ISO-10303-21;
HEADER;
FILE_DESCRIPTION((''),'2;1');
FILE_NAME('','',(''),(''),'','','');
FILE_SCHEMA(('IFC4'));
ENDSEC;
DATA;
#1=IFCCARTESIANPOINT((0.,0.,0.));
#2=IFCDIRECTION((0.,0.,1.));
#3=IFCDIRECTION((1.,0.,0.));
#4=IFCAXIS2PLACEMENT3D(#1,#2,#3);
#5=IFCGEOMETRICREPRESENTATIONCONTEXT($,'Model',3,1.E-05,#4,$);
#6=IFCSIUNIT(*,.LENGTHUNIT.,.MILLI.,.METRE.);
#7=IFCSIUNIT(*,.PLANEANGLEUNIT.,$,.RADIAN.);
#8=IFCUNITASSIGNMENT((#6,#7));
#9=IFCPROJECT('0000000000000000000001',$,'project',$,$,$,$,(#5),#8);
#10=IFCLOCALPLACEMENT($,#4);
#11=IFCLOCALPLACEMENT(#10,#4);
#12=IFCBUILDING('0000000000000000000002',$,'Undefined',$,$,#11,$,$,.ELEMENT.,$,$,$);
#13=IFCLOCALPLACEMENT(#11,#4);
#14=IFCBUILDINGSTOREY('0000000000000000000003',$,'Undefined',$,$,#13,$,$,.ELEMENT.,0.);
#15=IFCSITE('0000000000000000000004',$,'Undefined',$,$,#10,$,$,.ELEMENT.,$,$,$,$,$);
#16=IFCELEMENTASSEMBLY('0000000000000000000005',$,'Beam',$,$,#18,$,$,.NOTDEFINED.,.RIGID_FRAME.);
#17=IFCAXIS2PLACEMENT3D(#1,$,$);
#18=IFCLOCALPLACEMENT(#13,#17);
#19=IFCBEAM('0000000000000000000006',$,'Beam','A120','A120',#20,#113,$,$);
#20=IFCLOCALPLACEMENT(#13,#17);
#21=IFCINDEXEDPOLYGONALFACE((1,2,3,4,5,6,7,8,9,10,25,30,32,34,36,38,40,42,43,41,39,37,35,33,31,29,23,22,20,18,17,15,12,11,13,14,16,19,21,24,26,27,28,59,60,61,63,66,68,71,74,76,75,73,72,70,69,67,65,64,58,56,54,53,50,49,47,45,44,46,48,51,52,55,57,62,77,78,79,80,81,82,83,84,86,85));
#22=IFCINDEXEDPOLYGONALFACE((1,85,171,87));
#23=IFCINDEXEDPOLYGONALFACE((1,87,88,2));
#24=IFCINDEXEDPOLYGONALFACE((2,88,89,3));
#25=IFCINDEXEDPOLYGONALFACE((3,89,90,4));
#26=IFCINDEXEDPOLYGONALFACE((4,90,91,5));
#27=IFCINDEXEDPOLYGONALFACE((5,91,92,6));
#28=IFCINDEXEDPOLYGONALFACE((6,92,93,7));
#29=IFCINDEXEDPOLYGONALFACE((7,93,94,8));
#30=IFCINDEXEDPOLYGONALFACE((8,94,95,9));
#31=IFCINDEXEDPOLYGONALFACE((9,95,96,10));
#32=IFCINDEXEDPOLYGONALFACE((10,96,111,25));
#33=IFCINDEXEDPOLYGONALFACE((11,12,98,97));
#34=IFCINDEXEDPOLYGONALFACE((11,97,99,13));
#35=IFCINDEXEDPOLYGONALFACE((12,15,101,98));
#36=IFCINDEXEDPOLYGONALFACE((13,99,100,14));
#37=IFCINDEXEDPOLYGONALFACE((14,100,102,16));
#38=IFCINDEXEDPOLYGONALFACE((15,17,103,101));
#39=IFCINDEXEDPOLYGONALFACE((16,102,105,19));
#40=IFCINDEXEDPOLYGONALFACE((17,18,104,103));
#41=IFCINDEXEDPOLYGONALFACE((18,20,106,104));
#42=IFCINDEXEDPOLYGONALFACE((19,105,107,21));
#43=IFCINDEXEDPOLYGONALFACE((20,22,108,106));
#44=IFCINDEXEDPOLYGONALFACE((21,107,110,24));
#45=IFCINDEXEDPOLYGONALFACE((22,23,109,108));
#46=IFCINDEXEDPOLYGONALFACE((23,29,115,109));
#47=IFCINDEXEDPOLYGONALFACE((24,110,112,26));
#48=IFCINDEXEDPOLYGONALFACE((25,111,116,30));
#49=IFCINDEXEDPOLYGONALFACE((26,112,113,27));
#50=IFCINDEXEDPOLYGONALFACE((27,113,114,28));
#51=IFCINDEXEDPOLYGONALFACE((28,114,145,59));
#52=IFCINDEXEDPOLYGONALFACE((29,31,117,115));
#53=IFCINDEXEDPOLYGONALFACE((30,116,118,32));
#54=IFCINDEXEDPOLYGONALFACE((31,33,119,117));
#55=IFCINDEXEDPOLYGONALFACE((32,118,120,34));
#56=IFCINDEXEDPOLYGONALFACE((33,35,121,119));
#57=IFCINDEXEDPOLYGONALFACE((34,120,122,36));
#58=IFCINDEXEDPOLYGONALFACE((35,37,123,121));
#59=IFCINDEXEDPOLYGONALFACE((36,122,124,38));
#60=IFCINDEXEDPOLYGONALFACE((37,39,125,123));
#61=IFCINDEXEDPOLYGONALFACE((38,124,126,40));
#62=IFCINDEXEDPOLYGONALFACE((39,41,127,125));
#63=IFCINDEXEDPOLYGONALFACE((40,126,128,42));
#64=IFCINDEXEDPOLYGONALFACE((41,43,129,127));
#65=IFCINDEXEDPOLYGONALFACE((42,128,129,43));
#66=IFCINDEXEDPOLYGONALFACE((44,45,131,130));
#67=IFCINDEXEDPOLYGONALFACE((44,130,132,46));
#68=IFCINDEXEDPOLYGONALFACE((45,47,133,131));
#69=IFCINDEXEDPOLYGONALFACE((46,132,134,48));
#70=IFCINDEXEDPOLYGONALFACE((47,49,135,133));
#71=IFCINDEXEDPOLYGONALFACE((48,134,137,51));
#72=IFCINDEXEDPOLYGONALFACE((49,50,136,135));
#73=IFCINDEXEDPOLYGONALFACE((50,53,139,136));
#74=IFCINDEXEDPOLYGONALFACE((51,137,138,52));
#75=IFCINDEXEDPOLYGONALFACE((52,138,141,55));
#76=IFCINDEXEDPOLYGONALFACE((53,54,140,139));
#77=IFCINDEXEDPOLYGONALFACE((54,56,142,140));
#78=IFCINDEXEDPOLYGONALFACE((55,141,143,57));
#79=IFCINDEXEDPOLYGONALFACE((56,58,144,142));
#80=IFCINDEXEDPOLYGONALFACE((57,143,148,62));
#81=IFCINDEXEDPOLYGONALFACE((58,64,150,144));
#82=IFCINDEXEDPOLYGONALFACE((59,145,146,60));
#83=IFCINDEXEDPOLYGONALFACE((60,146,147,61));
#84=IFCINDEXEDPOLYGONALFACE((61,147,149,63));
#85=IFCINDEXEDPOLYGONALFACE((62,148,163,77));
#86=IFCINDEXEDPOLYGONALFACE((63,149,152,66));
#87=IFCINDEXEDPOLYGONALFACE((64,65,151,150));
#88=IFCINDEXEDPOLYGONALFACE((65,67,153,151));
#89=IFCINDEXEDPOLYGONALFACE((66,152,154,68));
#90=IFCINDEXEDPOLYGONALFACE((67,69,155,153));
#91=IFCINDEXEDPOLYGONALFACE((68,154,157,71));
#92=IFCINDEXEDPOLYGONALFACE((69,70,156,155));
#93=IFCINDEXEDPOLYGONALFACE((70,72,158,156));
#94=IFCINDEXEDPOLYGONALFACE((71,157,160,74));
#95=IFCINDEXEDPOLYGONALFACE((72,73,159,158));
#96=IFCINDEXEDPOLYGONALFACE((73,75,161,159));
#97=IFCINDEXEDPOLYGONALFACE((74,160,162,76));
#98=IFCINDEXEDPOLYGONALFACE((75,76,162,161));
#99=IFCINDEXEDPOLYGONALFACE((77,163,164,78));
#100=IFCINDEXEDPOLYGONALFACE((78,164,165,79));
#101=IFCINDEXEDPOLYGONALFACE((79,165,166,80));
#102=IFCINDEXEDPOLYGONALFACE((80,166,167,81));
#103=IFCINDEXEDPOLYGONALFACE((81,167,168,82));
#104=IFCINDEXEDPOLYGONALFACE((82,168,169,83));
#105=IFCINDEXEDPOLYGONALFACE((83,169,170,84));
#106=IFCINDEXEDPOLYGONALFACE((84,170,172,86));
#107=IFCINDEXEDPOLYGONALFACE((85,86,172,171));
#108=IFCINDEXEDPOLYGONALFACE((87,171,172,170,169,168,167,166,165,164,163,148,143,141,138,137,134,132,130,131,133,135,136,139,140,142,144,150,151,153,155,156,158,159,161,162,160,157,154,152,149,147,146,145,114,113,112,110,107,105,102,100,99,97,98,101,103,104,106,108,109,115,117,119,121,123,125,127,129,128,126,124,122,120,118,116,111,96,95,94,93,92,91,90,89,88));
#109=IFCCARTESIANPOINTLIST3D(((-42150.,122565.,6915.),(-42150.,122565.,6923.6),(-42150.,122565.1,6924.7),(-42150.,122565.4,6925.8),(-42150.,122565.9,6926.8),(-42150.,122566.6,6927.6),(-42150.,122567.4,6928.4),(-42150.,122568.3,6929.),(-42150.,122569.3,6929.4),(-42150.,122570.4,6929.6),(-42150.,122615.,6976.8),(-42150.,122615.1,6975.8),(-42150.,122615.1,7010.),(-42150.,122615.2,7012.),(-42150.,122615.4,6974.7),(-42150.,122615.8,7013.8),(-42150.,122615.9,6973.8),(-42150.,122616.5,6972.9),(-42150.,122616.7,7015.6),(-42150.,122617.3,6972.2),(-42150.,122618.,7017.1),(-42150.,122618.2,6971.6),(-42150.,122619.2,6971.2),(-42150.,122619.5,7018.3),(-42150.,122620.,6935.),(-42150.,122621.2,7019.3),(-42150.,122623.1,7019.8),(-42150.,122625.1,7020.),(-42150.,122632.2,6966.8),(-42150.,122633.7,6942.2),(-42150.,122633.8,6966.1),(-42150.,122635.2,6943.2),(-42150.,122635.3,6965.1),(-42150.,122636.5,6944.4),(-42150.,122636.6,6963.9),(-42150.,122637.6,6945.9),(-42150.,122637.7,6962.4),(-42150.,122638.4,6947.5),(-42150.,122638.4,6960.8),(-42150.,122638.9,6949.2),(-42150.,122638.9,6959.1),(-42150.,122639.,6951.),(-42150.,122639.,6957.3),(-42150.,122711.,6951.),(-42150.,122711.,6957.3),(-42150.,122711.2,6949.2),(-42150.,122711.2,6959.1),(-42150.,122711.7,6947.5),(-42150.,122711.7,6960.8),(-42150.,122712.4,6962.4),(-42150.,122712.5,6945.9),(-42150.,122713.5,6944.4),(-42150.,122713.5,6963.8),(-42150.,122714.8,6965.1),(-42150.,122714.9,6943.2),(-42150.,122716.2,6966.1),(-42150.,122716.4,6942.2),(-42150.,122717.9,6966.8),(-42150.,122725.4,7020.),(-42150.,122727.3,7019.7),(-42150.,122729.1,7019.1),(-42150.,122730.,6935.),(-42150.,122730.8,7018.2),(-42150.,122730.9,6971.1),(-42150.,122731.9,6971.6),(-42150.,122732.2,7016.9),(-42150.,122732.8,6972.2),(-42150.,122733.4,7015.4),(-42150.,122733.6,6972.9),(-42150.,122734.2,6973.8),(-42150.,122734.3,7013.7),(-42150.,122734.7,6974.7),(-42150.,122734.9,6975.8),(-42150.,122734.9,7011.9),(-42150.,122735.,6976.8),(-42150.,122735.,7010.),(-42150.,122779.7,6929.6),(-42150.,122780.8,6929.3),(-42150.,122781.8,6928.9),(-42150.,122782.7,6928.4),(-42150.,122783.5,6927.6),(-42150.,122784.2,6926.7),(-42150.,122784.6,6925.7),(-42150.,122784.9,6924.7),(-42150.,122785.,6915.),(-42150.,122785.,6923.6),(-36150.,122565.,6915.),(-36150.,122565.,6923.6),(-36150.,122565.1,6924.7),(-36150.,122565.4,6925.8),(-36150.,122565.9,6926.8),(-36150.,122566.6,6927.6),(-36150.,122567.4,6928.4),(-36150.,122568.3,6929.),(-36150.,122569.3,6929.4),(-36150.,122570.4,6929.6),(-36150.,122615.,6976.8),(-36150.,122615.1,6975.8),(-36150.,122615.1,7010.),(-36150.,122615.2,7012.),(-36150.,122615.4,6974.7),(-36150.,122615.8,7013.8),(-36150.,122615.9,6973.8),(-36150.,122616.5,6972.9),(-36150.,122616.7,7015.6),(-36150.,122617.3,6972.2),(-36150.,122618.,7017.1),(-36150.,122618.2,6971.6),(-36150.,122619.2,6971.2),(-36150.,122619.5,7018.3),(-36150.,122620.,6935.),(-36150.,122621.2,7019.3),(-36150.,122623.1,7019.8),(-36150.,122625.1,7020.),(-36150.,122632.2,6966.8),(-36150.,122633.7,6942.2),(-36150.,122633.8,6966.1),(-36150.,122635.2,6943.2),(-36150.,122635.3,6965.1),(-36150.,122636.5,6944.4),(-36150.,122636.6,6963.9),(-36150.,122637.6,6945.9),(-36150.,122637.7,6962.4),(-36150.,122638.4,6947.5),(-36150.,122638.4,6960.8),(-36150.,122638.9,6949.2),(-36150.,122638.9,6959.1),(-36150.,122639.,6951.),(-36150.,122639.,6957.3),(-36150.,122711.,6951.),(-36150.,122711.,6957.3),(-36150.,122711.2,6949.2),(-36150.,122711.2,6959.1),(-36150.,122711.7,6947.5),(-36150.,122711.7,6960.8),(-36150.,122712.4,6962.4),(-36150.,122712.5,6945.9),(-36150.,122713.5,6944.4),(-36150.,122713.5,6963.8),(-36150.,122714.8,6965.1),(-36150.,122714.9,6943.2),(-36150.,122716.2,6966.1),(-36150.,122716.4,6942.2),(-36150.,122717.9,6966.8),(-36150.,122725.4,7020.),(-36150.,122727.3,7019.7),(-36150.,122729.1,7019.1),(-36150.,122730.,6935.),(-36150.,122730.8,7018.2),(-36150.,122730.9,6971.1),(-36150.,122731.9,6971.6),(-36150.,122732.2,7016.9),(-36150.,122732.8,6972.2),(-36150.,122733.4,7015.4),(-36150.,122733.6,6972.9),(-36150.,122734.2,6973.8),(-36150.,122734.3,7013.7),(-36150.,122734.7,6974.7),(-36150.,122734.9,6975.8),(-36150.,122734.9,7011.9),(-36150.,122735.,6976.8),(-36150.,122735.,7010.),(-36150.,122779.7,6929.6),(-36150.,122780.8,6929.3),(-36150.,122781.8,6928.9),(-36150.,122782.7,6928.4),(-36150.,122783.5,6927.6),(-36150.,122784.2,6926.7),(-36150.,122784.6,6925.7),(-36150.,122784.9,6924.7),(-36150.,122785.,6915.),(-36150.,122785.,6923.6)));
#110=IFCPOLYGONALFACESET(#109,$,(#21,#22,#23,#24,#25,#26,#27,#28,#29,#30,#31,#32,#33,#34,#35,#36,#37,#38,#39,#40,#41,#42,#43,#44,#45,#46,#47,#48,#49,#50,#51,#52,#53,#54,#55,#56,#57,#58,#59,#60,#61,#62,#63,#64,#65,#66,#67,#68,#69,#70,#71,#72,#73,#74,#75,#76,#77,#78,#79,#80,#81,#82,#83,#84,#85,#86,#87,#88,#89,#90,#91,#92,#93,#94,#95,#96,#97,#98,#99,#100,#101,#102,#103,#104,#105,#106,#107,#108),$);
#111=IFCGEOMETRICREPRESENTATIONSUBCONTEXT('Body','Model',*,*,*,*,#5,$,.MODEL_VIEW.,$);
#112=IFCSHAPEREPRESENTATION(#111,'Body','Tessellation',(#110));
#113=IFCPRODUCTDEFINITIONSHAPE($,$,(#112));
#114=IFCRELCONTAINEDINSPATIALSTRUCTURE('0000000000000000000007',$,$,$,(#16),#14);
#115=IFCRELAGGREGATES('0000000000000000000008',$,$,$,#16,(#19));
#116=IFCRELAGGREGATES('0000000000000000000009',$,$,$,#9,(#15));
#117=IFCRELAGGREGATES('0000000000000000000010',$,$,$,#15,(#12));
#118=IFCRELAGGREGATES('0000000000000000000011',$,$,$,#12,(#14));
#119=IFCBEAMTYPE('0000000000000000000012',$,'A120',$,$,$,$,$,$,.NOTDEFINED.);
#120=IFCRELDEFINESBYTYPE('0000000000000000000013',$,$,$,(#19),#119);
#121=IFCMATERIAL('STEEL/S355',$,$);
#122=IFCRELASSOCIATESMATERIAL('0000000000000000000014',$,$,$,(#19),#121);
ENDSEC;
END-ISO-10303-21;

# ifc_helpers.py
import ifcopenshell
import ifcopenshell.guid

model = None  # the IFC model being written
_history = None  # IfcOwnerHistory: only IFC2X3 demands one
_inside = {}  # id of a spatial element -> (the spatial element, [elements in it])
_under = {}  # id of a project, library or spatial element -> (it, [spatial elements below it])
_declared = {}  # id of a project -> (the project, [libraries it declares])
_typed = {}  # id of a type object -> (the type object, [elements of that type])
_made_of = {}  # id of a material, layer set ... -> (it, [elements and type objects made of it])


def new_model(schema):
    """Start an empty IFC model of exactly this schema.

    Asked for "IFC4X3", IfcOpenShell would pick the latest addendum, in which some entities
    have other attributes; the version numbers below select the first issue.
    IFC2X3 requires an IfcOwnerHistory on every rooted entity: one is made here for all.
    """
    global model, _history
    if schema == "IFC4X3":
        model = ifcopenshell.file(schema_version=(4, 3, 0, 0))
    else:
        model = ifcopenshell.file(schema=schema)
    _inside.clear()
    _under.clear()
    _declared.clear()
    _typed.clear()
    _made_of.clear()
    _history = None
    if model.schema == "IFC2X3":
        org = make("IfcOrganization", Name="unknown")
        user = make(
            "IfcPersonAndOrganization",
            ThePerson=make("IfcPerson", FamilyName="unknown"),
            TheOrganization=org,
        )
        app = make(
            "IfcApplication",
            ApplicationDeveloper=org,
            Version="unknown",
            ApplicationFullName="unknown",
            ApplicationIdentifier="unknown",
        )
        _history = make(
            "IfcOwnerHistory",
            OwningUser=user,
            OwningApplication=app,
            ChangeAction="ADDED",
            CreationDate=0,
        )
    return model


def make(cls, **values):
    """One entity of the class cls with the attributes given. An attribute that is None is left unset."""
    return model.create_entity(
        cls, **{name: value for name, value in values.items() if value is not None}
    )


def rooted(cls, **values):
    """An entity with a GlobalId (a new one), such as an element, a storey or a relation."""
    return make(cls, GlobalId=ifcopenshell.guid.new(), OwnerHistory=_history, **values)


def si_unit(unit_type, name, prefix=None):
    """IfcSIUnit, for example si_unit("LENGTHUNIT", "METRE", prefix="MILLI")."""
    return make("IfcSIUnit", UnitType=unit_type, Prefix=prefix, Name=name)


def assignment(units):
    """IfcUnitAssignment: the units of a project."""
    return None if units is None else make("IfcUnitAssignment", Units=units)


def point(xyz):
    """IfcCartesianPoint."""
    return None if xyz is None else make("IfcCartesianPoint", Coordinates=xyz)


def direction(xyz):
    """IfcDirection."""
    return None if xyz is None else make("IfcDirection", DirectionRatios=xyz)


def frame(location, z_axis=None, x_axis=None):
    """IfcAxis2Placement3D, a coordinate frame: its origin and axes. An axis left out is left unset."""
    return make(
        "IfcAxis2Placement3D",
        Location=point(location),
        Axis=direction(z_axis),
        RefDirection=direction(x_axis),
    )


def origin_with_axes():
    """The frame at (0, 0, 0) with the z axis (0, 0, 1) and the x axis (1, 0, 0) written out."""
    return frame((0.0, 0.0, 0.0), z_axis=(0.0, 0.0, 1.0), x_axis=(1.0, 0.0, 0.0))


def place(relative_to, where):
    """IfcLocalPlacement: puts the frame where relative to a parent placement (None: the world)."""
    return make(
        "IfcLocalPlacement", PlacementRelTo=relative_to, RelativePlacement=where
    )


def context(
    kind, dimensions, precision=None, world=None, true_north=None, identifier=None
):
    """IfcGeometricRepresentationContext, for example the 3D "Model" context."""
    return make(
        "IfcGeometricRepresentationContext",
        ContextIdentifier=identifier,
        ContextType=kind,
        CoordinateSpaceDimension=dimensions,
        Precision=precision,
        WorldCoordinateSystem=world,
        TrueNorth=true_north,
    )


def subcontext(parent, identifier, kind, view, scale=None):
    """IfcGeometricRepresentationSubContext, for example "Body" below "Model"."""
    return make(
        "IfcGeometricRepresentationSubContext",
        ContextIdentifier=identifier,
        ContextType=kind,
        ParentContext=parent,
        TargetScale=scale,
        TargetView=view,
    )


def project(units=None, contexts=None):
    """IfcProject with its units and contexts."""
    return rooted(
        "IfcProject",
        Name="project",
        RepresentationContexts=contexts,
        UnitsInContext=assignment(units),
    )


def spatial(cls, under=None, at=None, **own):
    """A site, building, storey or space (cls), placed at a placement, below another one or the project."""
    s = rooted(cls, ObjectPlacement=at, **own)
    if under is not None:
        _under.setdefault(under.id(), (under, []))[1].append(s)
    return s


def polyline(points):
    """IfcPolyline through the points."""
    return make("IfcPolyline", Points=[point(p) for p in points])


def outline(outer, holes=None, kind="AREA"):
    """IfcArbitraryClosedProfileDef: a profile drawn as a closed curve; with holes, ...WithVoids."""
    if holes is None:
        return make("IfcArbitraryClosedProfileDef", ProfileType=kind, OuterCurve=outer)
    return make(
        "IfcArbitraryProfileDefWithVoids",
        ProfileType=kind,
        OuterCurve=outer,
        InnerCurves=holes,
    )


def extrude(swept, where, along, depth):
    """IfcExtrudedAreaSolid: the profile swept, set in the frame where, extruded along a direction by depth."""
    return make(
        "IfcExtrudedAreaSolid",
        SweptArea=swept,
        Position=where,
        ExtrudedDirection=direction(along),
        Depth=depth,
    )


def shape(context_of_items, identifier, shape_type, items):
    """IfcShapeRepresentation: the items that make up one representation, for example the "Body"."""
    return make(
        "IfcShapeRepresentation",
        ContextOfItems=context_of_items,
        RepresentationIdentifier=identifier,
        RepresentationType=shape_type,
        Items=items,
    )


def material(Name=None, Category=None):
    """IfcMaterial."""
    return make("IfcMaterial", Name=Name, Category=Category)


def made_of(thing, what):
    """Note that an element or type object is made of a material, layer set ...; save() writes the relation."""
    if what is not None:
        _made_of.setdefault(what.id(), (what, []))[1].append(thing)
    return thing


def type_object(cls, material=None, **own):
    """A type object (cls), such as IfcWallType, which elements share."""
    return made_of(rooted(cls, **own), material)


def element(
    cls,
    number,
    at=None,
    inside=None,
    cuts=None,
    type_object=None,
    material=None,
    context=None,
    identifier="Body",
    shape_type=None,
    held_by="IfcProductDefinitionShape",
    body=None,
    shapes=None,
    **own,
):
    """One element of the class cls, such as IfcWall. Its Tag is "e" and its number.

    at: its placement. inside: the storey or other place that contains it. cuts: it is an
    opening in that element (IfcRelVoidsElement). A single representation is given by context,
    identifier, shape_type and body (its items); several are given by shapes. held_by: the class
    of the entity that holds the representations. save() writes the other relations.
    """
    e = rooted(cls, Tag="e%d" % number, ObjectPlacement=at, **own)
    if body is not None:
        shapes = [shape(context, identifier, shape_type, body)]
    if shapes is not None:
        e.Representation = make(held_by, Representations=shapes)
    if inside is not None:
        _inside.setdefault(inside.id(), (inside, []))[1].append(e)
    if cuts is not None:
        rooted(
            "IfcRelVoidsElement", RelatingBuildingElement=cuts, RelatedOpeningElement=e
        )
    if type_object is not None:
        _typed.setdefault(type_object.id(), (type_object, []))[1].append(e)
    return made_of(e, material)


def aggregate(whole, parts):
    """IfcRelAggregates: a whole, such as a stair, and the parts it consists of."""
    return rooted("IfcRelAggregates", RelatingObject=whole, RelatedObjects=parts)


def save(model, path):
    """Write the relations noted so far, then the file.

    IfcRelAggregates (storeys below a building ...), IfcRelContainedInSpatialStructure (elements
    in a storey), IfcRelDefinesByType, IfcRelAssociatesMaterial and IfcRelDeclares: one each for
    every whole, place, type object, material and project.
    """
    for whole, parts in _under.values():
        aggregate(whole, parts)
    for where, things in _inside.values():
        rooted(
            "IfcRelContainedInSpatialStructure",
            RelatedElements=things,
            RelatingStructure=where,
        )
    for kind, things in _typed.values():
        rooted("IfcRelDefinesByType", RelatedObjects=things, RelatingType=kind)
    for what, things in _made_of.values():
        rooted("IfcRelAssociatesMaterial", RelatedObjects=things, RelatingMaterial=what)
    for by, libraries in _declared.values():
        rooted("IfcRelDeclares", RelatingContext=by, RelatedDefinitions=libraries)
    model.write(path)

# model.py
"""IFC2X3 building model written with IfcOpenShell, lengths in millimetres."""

from ifc_helpers import new_model, si_unit, frame, origin_with_axes, place, context, subcontext, project, spatial, polyline, outline, extrude, material, type_object, element, aggregate, save


model = new_model("IFC2X3")

# Units and contexts
model_context = context("Model", 3, precision=1e-05, world=origin_with_axes())
body_context = subcontext(model_context, "Body", "Model", "MODEL_VIEW")
ifc_project = project(units=[si_unit("LENGTHUNIT", "METRE", prefix="MILLI"), si_unit("PLANEANGLEUNIT", "RADIAN")], contexts=[model_context])

# Site, building, storey
site_placement = place(None, origin_with_axes())
site = spatial("IfcSite", under=ifc_project, at=site_placement, Name="Undefined", CompositionType="ELEMENT")
building_placement = place(site_placement, origin_with_axes())
building = spatial("IfcBuilding", under=site, at=building_placement, Name="Undefined", CompositionType="ELEMENT")
storey_placement = place(building_placement, origin_with_axes())
storey = spatial("IfcBuildingStorey", under=building, at=storey_placement, Name="Undefined", CompositionType="ELEMENT", Elevation=0.0)

# Element assembly, beam
ifc_material_1 = material(Name="STEEL/S355")
assembly_1_placement = place(storey_placement, origin_with_axes())
assembly_1 = element("IfcElementAssembly", 1, at=assembly_1_placement, inside=storey, Name="Beam", AssemblyPlace="NOTDEFINED", PredefinedType="RIGID_FRAME")
beam_type_1 = type_object("IfcBeamType", Name="A120", PredefinedType="NOTDEFINED")
beam_1_placement = place(assembly_1_placement, frame((-42150.0, 122675.0, 6967.5), z_axis=(0.0, 0.000118, 1.0), x_axis=(1.0, 0.0, 0.0)))
beam_1 = element("IfcBeam", 2, at=beam_1_placement, type_object=beam_type_1, material=ifc_material_1, Name="Beam", Description="A120", ObjectType="A120", context=body_context, shape_type="SweptSolid", body=[
    extrude(outline(polyline([(-110.0, -52.5), (-110.0, -43.9), (-109.9, -42.8), (-109.6, -41.8), (-109.1, -40.8), (-108.5, -39.9), (-107.7, -39.1), (-106.7, -38.6), (-105.7, -38.2), (-104.7, -37.9), (-55.0, -32.5), (-41.3, -25.3), (-39.8, -24.3), (-38.5, -23.1), (-37.4, -21.6), (-36.6, -20.0), (-36.2, -18.3), (-36.0, -16.5), (-36.0, -10.2), (-36.1, -8.4), (-36.6, -6.7), (-37.4, -5.1), (-38.4, -3.7), (-39.7, -2.4), (-41.2, -1.4), (-42.8, -0.7), (-55.9, 3.6), (-56.9, 4.1), (-57.8, 4.7), (-58.5, 5.4), (-59.2, 6.3), (-59.6, 7.2), (-59.9, 8.3), (-60.0, 9.3), (-60.0, 42.5), (-59.8, 44.4), (-59.3, 46.2), (-58.4, 47.9), (-57.2, 49.4), (-55.7, 50.7), (-54.1, 51.6), (-52.3, 52.2), (-50.4, 52.5), (50.0, 52.5), (51.9, 52.3), (53.8, 51.7), (55.5, 50.8), (57.1, 49.6), (58.3, 48.1), (59.2, 46.3), (59.8, 44.4), (60.0, 42.5), (60.0, 9.3), (59.9, 8.3), (59.6, 7.2), (59.2, 6.3), (58.5, 5.4), (57.8, 4.7), (56.9, 4.1), (55.9, 3.6), (42.8, -0.7), (41.2, -1.4), (39.7, -2.4), (38.4, -3.7), (37.4, -5.1), (36.6, -6.7), (36.1, -8.4), (36.0, -10.2), (36.0, -16.5), (36.2, -18.3), (36.6, -20.0), (37.4, -21.6), (38.5, -23.1), (39.8, -24.3), (41.3, -25.3), (55.0, -32.5), (104.7, -37.9), (105.7, -38.2), (106.7, -38.6), (107.7, -39.1), (108.5, -39.9), (109.1, -40.8), (109.6, -41.8), (109.9, -42.8), (110.0, -43.9), (110.0, -52.5), (-110.0, -52.5)])), frame((6000.0, 0.0, 0.0), z_axis=(-1.0, 0.0, 0.0), x_axis=(0.0, -1.0, 0.0)), (0.0, 0.0, 1.0), 6000.0),
])
aggregate(assembly_1, [beam_1])

save(model, "model.ifc")
